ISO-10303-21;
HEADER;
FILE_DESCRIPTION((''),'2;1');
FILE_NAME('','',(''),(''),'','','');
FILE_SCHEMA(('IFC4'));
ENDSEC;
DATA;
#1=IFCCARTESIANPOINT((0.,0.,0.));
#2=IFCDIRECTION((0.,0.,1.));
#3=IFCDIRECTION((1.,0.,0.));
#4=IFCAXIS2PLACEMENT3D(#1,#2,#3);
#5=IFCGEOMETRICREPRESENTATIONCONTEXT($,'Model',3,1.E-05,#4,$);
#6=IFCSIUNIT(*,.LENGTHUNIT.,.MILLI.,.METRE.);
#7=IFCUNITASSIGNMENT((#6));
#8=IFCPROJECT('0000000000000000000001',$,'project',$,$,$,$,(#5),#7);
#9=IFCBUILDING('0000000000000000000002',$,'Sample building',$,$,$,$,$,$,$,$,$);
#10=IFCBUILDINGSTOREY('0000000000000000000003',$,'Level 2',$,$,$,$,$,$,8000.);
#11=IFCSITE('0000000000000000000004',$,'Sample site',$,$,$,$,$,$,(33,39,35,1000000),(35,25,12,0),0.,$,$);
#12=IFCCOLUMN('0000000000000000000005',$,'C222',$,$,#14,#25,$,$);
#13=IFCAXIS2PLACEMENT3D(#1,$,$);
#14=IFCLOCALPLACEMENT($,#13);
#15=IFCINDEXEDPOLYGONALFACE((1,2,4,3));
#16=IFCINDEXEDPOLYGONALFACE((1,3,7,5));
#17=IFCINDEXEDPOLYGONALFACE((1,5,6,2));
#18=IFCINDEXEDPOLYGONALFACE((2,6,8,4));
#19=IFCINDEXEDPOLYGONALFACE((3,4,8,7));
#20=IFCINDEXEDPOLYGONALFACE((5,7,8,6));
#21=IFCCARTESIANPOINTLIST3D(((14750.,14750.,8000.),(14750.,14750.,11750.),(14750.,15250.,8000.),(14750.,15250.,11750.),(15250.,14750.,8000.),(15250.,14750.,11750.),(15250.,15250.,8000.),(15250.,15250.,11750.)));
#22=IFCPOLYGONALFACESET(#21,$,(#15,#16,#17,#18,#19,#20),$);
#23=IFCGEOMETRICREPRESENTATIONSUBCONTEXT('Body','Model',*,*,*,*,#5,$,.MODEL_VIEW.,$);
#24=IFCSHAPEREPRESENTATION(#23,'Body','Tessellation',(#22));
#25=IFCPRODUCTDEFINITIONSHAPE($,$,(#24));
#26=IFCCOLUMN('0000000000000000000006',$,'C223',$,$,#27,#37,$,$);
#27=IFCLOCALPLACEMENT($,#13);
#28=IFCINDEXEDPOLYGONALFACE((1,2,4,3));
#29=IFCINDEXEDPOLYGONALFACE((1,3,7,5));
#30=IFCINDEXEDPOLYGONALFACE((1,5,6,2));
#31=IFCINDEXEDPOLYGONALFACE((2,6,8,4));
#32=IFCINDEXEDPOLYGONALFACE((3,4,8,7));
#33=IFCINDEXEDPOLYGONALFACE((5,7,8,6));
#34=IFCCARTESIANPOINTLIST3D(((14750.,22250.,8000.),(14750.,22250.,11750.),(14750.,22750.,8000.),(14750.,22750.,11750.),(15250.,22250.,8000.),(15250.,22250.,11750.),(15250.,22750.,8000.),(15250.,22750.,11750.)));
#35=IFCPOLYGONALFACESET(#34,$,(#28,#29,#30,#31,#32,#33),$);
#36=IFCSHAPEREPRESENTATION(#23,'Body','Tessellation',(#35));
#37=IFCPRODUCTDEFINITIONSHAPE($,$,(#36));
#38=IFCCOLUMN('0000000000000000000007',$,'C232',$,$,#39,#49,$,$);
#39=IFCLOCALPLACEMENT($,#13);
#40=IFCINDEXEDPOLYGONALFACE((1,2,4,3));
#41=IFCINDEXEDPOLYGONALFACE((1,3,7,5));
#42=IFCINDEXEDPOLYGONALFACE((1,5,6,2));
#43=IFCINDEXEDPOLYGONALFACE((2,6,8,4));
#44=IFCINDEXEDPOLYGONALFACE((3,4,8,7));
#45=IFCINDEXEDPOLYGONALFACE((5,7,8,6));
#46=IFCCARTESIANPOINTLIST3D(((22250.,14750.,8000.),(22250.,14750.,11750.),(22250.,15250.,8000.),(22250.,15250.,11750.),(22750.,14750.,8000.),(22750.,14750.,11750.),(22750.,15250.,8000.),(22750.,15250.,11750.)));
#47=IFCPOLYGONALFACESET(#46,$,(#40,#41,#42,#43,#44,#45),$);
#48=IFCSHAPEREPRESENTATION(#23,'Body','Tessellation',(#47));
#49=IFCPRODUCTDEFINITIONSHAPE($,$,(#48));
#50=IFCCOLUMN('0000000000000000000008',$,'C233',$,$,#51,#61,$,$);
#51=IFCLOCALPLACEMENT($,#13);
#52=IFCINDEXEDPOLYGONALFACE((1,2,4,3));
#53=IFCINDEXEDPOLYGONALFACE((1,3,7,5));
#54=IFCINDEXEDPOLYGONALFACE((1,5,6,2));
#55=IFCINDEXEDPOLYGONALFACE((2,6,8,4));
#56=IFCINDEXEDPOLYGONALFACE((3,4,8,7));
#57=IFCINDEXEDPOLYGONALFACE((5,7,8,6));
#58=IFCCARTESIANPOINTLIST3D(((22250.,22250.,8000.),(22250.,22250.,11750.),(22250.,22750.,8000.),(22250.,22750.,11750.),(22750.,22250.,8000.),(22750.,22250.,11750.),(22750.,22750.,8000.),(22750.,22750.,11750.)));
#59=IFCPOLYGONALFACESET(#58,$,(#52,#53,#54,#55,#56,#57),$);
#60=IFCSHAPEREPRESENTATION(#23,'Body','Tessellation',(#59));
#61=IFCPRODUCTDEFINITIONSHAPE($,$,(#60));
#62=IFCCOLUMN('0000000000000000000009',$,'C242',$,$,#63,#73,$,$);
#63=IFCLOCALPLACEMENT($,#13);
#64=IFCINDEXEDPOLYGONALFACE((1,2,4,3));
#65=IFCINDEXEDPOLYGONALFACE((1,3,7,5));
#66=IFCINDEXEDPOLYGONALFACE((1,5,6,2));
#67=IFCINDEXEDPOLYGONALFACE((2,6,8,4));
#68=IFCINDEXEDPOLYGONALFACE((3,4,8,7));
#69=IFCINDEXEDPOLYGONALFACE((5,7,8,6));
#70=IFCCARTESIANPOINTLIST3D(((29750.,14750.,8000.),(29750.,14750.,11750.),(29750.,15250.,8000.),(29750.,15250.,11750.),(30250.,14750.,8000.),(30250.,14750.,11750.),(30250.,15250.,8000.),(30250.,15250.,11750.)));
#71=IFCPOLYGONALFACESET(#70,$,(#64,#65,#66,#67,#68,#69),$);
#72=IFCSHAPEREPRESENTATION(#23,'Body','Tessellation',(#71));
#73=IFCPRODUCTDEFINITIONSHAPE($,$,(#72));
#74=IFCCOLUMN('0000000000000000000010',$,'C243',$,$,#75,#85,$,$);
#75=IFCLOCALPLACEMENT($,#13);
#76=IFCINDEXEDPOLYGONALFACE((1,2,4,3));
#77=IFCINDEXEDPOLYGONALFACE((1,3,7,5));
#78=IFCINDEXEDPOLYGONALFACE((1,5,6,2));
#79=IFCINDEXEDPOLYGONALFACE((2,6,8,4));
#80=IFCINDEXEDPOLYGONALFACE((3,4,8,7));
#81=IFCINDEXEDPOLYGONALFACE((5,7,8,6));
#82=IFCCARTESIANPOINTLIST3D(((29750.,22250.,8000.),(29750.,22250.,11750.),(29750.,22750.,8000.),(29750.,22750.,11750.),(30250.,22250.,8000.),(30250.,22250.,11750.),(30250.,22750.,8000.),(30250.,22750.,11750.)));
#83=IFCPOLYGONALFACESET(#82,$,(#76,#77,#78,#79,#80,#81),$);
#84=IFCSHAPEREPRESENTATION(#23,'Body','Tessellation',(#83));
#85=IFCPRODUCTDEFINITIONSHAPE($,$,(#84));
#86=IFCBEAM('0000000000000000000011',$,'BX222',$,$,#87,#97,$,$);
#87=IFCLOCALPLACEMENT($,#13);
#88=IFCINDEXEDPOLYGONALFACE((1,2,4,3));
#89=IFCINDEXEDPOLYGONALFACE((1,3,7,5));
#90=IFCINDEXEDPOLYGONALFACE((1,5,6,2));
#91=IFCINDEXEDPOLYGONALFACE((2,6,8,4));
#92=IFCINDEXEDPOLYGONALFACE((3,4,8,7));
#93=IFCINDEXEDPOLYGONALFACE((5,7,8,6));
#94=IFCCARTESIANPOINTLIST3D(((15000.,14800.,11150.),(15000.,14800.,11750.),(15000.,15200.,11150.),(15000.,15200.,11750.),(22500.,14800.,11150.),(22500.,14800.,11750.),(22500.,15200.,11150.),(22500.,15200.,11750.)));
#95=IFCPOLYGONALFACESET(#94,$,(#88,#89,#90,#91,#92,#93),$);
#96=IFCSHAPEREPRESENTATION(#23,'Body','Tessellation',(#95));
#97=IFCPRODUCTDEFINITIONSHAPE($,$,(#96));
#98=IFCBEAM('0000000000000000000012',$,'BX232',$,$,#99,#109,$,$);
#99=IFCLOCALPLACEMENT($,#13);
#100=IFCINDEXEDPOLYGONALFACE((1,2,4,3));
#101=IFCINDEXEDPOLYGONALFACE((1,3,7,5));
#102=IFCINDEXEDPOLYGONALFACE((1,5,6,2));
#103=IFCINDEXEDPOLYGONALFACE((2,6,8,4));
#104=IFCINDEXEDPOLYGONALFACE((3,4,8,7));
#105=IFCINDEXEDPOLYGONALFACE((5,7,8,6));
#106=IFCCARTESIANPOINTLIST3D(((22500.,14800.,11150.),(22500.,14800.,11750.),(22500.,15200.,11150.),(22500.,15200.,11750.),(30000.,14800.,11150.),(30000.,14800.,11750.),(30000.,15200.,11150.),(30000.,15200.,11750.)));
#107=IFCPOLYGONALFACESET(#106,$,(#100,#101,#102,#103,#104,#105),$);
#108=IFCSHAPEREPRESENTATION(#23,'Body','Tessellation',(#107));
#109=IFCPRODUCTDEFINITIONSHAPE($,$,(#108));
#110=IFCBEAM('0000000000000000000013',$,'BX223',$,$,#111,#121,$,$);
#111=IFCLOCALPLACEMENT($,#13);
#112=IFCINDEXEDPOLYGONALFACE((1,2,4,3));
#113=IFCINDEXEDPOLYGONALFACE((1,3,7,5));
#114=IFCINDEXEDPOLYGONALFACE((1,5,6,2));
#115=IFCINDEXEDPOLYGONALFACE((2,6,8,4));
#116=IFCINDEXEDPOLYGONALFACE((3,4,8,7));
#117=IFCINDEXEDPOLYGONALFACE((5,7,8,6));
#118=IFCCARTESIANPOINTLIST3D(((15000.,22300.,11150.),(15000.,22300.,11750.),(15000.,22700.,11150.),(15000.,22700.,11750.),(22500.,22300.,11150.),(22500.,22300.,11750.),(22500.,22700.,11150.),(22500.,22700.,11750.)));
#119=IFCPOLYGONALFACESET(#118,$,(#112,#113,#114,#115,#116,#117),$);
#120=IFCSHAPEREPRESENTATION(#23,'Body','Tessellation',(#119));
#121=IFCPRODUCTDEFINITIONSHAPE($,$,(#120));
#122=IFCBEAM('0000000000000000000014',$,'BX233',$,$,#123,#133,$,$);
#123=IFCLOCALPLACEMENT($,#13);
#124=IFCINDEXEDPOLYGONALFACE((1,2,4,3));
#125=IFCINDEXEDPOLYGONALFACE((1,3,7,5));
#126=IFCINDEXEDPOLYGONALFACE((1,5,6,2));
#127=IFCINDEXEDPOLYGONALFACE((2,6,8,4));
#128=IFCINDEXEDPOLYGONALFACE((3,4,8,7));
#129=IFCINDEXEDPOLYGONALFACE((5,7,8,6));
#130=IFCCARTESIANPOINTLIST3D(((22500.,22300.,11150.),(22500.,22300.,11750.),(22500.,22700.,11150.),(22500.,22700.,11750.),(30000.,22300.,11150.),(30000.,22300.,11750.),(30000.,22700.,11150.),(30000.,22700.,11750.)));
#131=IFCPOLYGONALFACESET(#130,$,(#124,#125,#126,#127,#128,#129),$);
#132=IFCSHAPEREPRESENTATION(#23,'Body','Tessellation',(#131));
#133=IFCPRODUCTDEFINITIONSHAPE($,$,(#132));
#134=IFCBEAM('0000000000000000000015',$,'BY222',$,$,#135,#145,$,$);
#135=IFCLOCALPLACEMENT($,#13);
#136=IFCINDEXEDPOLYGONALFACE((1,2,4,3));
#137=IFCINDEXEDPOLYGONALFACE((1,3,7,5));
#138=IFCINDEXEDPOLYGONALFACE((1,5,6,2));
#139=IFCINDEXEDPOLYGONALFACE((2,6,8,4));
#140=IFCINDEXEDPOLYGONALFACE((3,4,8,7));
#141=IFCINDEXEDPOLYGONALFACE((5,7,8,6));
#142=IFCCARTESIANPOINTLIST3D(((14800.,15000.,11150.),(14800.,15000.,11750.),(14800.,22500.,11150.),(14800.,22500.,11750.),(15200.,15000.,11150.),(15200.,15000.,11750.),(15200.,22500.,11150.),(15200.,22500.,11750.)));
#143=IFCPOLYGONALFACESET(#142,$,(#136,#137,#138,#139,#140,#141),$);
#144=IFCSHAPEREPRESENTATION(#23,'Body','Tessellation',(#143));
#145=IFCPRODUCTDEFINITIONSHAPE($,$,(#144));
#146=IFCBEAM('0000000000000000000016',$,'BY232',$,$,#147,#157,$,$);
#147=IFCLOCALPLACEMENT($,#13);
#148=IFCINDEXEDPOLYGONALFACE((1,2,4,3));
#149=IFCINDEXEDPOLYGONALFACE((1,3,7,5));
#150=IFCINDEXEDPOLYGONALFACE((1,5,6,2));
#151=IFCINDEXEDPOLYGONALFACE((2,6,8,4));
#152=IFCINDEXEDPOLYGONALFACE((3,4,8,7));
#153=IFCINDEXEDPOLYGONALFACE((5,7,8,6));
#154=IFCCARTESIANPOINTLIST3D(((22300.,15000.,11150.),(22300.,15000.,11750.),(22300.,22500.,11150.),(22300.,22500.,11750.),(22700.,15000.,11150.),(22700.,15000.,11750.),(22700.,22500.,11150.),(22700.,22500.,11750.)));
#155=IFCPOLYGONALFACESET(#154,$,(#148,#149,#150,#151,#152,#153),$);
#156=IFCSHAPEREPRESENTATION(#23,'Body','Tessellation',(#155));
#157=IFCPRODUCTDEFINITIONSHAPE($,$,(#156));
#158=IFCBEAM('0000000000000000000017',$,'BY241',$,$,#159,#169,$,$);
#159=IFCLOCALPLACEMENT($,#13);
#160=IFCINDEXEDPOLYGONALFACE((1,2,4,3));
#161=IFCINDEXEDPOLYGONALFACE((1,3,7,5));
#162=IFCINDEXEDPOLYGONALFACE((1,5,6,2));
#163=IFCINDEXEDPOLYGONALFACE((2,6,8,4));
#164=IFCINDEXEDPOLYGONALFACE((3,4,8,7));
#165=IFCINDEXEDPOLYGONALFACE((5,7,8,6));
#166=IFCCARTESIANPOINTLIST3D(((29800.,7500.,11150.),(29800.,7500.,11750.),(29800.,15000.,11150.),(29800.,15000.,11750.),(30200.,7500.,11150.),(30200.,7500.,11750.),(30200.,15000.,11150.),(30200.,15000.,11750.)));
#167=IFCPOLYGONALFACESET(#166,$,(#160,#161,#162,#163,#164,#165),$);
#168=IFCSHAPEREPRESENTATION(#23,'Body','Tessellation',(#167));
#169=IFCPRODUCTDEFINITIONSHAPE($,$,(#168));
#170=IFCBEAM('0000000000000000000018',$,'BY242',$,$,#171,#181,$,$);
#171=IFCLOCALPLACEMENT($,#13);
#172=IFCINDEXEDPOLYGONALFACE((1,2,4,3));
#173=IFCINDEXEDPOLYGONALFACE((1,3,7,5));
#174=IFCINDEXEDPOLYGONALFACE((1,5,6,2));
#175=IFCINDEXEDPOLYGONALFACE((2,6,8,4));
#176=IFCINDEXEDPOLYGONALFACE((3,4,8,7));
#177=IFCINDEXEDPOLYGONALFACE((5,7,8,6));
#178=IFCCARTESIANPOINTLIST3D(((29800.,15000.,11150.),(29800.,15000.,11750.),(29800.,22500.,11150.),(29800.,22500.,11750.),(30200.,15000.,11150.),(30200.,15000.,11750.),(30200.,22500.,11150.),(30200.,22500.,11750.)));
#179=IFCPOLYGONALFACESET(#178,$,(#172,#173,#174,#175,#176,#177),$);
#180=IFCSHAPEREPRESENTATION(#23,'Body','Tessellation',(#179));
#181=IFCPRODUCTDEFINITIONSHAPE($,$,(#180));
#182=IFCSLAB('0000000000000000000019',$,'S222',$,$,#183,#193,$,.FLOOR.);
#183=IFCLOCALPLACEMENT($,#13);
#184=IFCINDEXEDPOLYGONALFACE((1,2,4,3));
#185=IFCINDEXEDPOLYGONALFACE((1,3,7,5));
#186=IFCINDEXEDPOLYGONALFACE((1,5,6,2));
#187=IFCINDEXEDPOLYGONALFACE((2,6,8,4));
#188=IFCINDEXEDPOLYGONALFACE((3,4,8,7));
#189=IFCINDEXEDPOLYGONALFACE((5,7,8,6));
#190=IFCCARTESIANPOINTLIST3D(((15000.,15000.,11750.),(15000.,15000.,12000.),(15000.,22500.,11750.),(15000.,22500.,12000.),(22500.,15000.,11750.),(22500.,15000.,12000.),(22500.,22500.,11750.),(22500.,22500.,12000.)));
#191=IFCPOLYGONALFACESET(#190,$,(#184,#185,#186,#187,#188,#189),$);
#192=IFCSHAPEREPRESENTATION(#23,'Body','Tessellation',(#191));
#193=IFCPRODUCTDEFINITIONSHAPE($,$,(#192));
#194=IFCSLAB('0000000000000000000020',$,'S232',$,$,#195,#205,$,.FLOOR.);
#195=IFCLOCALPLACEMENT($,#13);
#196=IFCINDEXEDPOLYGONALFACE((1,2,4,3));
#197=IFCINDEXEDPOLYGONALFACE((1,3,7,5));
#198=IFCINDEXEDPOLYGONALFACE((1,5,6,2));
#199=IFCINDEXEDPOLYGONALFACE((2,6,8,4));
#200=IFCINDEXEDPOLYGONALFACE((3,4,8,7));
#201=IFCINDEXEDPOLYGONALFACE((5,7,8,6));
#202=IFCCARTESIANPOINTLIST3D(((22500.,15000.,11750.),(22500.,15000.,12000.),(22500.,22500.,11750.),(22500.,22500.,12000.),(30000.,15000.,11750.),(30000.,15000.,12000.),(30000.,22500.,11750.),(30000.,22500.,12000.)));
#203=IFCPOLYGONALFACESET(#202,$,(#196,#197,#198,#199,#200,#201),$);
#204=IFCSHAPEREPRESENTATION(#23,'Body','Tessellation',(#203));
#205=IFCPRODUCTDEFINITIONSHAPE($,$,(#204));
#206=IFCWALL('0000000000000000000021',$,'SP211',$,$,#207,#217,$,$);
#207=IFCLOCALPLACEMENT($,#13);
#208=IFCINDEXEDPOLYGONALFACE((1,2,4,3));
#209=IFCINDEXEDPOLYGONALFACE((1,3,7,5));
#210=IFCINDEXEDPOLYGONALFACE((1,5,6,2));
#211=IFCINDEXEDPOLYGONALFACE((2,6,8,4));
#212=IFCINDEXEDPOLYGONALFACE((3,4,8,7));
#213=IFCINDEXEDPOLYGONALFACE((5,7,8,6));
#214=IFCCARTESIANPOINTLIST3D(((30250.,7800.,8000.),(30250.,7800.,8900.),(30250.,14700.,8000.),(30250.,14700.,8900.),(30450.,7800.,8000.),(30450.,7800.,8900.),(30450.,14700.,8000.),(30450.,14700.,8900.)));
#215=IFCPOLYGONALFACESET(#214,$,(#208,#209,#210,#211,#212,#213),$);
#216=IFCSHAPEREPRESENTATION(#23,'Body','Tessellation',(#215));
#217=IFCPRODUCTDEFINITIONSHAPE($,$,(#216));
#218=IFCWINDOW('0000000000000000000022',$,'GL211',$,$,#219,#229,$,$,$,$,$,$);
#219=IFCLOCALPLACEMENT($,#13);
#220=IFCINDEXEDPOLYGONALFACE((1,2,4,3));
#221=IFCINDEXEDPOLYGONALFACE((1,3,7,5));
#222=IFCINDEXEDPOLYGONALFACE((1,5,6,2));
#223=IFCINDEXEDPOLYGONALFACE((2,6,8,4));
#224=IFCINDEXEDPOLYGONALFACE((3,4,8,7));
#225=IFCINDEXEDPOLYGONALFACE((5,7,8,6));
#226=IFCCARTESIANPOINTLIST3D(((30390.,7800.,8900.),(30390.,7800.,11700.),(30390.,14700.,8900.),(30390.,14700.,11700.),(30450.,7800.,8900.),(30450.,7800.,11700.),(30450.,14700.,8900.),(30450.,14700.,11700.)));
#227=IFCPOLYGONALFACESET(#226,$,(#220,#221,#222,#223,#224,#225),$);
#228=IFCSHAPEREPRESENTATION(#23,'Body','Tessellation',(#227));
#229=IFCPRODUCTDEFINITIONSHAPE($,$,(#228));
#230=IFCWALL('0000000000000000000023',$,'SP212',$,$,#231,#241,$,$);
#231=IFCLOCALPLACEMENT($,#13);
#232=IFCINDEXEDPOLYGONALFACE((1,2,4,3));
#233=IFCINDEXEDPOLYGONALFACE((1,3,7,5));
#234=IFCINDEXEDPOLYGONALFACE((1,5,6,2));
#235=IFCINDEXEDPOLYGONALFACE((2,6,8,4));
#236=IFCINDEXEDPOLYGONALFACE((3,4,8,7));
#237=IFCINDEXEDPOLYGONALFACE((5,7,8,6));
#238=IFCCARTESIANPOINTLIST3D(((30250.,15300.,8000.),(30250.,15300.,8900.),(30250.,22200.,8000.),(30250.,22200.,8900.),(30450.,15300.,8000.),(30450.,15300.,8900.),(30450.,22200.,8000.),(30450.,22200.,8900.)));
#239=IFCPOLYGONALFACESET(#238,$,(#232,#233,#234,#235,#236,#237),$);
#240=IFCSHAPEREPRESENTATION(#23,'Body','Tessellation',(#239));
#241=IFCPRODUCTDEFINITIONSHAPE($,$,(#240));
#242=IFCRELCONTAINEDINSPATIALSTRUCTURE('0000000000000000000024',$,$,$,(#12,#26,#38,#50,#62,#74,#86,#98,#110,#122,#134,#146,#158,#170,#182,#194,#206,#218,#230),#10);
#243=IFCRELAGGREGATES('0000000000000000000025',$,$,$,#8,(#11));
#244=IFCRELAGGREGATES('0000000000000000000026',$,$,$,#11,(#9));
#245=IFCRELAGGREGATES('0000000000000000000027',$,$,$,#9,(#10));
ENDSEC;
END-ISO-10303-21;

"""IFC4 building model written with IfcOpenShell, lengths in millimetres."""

from ifc_helpers import new_model, si_unit, frame, origin_with_axes, place, context, subcontext, project, spatial, indexed_curve, outline, extrude, element, save


model = new_model("IFC4")

# Units and contexts
model_context = context("Model", 3, precision=1e-05, world=origin_with_axes())
body_context = subcontext(model_context, "Body", "Model", "MODEL_VIEW")
ifc_project = project(units=[si_unit("LENGTHUNIT", "METRE", prefix="MILLI")], contexts=[model_context])

# Site, building, storey
site = spatial("IfcSite", under=ifc_project, Name="Sample site", RefLatitude=(33, 39, 35, 1000000), RefLongitude=(35, 25, 12, 0), RefElevation=0.0)
building = spatial("IfcBuilding", under=site, Name="Sample building")
storey = spatial("IfcBuildingStorey", under=building, Name="Level 2", Elevation=8000.0)

# Columns
for number, where, z_axis, x_axis, name in (
    (1, (14750.0, 14750.0, 8000.0), (0.0, 0.0, 1.0), (1.0, 0.0, 0.0), "C222"),
    (2, (14750.0, 22250.0, 8000.0), (0.0, 0.0, 1.0), (1.0, 0.0, 0.0), "C223"),
    (3, (22250.0, 14750.0, 8000.0), (0.0, 0.0, 1.0), (1.0, 0.0, 0.0), "C232"),
    (4, (22250.0, 22250.0, 8000.0), (0.0, 0.0, 1.0), (1.0, 0.0, 0.0), "C233"),
    (5, (29750.0, 14750.0, 8000.0), (0.0, 0.0, 1.0), (1.0, 0.0, 0.0), "C242"),
    (6, (29750.0, 22250.0, 8000.0), (0.0, 0.0, 1.0), (1.0, 0.0, 0.0), "C243"),
):
    element("IfcColumn", number, at=place(None, frame(where, z_axis=z_axis, x_axis=x_axis)), inside=storey, Name=name, context=body_context, shape_type="SweptSolid", body=[
        extrude(outline(indexed_curve([(0.0, 0.0), (0.0, 500.0), (500.0, 500.0), (500.0, 0.0), (0.0, 0.0)], self_intersect=False)), origin_with_axes(), (0.0, 0.0, 1.0), 3750.0),
    ])

# Beams
for number, where, z_axis, x_axis, name in (
    (7, (15000.0, 14800.0, 11150.0), (0.0, 0.0, 1.0), (1.0, 0.0, 0.0), "BX222"),
    (8, (22500.0, 14800.0, 11150.0), (0.0, 0.0, 1.0), (1.0, 0.0, 0.0), "BX232"),
    (9, (15000.0, 22300.0, 11150.0), (0.0, 0.0, 1.0), (1.0, 0.0, 0.0), "BX223"),
    (10, (22500.0, 22300.0, 11150.0), (0.0, 0.0, 1.0), (1.0, 0.0, 0.0), "BX233"),
    (11, (15200.0, 15000.0, 11150.0), (0.0, 0.0, 1.0), (0.0, 1.0, 0.0), "BY222"),
    (12, (22700.0, 15000.0, 11150.0), (0.0, 0.0, 1.0), (0.0, 1.0, 0.0), "BY232"),
    (13, (30200.0, 7500.0, 11150.0), (0.0, 0.0, 1.0), (0.0, 1.0, 0.0), "BY241"),
    (14, (30200.0, 15000.0, 11150.0), (0.0, 0.0, 1.0), (0.0, 1.0, 0.0), "BY242"),
):
    element("IfcBeam", number, at=place(None, frame(where, z_axis=z_axis, x_axis=x_axis)), inside=storey, Name=name, context=body_context, shape_type="SweptSolid", body=[
        extrude(outline(indexed_curve([(0.0, 0.0), (0.0, 400.0), (7500.0, 400.0), (7500.0, 0.0), (0.0, 0.0)], self_intersect=False)), origin_with_axes(), (0.0, 0.0, 1.0), 600.0),
    ])

# Slabs
for number, where, z_axis, x_axis, name in (
    (15, (15000.0, 15000.0, 11750.0), (0.0, 0.0, 1.0), (1.0, 0.0, 0.0), "S222"),
    (16, (22500.0, 15000.0, 11750.0), (0.0, 0.0, 1.0), (1.0, 0.0, 0.0), "S232"),
):
    element("IfcSlab", number, at=place(None, frame(where, z_axis=z_axis, x_axis=x_axis)), inside=storey, Name=name, PredefinedType="FLOOR", context=body_context, shape_type="SweptSolid", body=[
        extrude(outline(indexed_curve([(0.0, 0.0), (0.0, 7500.0), (7500.0, 7500.0), (7500.0, 0.0), (0.0, 0.0)], self_intersect=False)), origin_with_axes(), (0.0, 0.0, 1.0), 250.0),
    ])

# Wall
wall_1_placement = place(None, frame((30450.0, 7800.0, 8000.0), z_axis=(0.0, 0.0, 1.0), x_axis=(0.0, 1.0, 0.0)))
element("IfcWall", 17, at=wall_1_placement, inside=storey, Name="SP211", context=body_context, shape_type="SweptSolid", body=[
    extrude(outline(indexed_curve([(0.0, 0.0), (0.0, 200.0), (6900.0, 200.0), (6900.0, 0.0), (0.0, 0.0)], self_intersect=False)), origin_with_axes(), (0.0, 0.0, 1.0), 900.0),
])

# Window
window_1_placement = place(None, frame((30450.0, 7800.0, 8900.0), z_axis=(0.0, 0.0, 1.0), x_axis=(0.0, 1.0, 0.0)))
element("IfcWindow", 18, at=window_1_placement, inside=storey, Name="GL211", context=body_context, shape_type="SweptSolid", body=[
    extrude(outline(indexed_curve([(0.0, 0.0), (0.0, 60.0), (6900.0, 60.0), (6900.0, 0.0), (0.0, 0.0)], self_intersect=False)), origin_with_axes(), (0.0, 0.0, 1.0), 2800.0),
])

# Wall
wall_2_placement = place(None, frame((30450.0, 15300.0, 8000.0), z_axis=(0.0, 0.0, 1.0), x_axis=(0.0, 1.0, 0.0)))
element("IfcWall", 19, at=wall_2_placement, inside=storey, Name="SP212", context=body_context, shape_type="SweptSolid", body=[
    extrude(outline(indexed_curve([(0.0, 0.0), (0.0, 200.0), (6900.0, 200.0), (6900.0, 0.0), (0.0, 0.0)], self_intersect=False)), origin_with_axes(), (0.0, 0.0, 1.0), 900.0),
])

save(model, "model.ifc")
